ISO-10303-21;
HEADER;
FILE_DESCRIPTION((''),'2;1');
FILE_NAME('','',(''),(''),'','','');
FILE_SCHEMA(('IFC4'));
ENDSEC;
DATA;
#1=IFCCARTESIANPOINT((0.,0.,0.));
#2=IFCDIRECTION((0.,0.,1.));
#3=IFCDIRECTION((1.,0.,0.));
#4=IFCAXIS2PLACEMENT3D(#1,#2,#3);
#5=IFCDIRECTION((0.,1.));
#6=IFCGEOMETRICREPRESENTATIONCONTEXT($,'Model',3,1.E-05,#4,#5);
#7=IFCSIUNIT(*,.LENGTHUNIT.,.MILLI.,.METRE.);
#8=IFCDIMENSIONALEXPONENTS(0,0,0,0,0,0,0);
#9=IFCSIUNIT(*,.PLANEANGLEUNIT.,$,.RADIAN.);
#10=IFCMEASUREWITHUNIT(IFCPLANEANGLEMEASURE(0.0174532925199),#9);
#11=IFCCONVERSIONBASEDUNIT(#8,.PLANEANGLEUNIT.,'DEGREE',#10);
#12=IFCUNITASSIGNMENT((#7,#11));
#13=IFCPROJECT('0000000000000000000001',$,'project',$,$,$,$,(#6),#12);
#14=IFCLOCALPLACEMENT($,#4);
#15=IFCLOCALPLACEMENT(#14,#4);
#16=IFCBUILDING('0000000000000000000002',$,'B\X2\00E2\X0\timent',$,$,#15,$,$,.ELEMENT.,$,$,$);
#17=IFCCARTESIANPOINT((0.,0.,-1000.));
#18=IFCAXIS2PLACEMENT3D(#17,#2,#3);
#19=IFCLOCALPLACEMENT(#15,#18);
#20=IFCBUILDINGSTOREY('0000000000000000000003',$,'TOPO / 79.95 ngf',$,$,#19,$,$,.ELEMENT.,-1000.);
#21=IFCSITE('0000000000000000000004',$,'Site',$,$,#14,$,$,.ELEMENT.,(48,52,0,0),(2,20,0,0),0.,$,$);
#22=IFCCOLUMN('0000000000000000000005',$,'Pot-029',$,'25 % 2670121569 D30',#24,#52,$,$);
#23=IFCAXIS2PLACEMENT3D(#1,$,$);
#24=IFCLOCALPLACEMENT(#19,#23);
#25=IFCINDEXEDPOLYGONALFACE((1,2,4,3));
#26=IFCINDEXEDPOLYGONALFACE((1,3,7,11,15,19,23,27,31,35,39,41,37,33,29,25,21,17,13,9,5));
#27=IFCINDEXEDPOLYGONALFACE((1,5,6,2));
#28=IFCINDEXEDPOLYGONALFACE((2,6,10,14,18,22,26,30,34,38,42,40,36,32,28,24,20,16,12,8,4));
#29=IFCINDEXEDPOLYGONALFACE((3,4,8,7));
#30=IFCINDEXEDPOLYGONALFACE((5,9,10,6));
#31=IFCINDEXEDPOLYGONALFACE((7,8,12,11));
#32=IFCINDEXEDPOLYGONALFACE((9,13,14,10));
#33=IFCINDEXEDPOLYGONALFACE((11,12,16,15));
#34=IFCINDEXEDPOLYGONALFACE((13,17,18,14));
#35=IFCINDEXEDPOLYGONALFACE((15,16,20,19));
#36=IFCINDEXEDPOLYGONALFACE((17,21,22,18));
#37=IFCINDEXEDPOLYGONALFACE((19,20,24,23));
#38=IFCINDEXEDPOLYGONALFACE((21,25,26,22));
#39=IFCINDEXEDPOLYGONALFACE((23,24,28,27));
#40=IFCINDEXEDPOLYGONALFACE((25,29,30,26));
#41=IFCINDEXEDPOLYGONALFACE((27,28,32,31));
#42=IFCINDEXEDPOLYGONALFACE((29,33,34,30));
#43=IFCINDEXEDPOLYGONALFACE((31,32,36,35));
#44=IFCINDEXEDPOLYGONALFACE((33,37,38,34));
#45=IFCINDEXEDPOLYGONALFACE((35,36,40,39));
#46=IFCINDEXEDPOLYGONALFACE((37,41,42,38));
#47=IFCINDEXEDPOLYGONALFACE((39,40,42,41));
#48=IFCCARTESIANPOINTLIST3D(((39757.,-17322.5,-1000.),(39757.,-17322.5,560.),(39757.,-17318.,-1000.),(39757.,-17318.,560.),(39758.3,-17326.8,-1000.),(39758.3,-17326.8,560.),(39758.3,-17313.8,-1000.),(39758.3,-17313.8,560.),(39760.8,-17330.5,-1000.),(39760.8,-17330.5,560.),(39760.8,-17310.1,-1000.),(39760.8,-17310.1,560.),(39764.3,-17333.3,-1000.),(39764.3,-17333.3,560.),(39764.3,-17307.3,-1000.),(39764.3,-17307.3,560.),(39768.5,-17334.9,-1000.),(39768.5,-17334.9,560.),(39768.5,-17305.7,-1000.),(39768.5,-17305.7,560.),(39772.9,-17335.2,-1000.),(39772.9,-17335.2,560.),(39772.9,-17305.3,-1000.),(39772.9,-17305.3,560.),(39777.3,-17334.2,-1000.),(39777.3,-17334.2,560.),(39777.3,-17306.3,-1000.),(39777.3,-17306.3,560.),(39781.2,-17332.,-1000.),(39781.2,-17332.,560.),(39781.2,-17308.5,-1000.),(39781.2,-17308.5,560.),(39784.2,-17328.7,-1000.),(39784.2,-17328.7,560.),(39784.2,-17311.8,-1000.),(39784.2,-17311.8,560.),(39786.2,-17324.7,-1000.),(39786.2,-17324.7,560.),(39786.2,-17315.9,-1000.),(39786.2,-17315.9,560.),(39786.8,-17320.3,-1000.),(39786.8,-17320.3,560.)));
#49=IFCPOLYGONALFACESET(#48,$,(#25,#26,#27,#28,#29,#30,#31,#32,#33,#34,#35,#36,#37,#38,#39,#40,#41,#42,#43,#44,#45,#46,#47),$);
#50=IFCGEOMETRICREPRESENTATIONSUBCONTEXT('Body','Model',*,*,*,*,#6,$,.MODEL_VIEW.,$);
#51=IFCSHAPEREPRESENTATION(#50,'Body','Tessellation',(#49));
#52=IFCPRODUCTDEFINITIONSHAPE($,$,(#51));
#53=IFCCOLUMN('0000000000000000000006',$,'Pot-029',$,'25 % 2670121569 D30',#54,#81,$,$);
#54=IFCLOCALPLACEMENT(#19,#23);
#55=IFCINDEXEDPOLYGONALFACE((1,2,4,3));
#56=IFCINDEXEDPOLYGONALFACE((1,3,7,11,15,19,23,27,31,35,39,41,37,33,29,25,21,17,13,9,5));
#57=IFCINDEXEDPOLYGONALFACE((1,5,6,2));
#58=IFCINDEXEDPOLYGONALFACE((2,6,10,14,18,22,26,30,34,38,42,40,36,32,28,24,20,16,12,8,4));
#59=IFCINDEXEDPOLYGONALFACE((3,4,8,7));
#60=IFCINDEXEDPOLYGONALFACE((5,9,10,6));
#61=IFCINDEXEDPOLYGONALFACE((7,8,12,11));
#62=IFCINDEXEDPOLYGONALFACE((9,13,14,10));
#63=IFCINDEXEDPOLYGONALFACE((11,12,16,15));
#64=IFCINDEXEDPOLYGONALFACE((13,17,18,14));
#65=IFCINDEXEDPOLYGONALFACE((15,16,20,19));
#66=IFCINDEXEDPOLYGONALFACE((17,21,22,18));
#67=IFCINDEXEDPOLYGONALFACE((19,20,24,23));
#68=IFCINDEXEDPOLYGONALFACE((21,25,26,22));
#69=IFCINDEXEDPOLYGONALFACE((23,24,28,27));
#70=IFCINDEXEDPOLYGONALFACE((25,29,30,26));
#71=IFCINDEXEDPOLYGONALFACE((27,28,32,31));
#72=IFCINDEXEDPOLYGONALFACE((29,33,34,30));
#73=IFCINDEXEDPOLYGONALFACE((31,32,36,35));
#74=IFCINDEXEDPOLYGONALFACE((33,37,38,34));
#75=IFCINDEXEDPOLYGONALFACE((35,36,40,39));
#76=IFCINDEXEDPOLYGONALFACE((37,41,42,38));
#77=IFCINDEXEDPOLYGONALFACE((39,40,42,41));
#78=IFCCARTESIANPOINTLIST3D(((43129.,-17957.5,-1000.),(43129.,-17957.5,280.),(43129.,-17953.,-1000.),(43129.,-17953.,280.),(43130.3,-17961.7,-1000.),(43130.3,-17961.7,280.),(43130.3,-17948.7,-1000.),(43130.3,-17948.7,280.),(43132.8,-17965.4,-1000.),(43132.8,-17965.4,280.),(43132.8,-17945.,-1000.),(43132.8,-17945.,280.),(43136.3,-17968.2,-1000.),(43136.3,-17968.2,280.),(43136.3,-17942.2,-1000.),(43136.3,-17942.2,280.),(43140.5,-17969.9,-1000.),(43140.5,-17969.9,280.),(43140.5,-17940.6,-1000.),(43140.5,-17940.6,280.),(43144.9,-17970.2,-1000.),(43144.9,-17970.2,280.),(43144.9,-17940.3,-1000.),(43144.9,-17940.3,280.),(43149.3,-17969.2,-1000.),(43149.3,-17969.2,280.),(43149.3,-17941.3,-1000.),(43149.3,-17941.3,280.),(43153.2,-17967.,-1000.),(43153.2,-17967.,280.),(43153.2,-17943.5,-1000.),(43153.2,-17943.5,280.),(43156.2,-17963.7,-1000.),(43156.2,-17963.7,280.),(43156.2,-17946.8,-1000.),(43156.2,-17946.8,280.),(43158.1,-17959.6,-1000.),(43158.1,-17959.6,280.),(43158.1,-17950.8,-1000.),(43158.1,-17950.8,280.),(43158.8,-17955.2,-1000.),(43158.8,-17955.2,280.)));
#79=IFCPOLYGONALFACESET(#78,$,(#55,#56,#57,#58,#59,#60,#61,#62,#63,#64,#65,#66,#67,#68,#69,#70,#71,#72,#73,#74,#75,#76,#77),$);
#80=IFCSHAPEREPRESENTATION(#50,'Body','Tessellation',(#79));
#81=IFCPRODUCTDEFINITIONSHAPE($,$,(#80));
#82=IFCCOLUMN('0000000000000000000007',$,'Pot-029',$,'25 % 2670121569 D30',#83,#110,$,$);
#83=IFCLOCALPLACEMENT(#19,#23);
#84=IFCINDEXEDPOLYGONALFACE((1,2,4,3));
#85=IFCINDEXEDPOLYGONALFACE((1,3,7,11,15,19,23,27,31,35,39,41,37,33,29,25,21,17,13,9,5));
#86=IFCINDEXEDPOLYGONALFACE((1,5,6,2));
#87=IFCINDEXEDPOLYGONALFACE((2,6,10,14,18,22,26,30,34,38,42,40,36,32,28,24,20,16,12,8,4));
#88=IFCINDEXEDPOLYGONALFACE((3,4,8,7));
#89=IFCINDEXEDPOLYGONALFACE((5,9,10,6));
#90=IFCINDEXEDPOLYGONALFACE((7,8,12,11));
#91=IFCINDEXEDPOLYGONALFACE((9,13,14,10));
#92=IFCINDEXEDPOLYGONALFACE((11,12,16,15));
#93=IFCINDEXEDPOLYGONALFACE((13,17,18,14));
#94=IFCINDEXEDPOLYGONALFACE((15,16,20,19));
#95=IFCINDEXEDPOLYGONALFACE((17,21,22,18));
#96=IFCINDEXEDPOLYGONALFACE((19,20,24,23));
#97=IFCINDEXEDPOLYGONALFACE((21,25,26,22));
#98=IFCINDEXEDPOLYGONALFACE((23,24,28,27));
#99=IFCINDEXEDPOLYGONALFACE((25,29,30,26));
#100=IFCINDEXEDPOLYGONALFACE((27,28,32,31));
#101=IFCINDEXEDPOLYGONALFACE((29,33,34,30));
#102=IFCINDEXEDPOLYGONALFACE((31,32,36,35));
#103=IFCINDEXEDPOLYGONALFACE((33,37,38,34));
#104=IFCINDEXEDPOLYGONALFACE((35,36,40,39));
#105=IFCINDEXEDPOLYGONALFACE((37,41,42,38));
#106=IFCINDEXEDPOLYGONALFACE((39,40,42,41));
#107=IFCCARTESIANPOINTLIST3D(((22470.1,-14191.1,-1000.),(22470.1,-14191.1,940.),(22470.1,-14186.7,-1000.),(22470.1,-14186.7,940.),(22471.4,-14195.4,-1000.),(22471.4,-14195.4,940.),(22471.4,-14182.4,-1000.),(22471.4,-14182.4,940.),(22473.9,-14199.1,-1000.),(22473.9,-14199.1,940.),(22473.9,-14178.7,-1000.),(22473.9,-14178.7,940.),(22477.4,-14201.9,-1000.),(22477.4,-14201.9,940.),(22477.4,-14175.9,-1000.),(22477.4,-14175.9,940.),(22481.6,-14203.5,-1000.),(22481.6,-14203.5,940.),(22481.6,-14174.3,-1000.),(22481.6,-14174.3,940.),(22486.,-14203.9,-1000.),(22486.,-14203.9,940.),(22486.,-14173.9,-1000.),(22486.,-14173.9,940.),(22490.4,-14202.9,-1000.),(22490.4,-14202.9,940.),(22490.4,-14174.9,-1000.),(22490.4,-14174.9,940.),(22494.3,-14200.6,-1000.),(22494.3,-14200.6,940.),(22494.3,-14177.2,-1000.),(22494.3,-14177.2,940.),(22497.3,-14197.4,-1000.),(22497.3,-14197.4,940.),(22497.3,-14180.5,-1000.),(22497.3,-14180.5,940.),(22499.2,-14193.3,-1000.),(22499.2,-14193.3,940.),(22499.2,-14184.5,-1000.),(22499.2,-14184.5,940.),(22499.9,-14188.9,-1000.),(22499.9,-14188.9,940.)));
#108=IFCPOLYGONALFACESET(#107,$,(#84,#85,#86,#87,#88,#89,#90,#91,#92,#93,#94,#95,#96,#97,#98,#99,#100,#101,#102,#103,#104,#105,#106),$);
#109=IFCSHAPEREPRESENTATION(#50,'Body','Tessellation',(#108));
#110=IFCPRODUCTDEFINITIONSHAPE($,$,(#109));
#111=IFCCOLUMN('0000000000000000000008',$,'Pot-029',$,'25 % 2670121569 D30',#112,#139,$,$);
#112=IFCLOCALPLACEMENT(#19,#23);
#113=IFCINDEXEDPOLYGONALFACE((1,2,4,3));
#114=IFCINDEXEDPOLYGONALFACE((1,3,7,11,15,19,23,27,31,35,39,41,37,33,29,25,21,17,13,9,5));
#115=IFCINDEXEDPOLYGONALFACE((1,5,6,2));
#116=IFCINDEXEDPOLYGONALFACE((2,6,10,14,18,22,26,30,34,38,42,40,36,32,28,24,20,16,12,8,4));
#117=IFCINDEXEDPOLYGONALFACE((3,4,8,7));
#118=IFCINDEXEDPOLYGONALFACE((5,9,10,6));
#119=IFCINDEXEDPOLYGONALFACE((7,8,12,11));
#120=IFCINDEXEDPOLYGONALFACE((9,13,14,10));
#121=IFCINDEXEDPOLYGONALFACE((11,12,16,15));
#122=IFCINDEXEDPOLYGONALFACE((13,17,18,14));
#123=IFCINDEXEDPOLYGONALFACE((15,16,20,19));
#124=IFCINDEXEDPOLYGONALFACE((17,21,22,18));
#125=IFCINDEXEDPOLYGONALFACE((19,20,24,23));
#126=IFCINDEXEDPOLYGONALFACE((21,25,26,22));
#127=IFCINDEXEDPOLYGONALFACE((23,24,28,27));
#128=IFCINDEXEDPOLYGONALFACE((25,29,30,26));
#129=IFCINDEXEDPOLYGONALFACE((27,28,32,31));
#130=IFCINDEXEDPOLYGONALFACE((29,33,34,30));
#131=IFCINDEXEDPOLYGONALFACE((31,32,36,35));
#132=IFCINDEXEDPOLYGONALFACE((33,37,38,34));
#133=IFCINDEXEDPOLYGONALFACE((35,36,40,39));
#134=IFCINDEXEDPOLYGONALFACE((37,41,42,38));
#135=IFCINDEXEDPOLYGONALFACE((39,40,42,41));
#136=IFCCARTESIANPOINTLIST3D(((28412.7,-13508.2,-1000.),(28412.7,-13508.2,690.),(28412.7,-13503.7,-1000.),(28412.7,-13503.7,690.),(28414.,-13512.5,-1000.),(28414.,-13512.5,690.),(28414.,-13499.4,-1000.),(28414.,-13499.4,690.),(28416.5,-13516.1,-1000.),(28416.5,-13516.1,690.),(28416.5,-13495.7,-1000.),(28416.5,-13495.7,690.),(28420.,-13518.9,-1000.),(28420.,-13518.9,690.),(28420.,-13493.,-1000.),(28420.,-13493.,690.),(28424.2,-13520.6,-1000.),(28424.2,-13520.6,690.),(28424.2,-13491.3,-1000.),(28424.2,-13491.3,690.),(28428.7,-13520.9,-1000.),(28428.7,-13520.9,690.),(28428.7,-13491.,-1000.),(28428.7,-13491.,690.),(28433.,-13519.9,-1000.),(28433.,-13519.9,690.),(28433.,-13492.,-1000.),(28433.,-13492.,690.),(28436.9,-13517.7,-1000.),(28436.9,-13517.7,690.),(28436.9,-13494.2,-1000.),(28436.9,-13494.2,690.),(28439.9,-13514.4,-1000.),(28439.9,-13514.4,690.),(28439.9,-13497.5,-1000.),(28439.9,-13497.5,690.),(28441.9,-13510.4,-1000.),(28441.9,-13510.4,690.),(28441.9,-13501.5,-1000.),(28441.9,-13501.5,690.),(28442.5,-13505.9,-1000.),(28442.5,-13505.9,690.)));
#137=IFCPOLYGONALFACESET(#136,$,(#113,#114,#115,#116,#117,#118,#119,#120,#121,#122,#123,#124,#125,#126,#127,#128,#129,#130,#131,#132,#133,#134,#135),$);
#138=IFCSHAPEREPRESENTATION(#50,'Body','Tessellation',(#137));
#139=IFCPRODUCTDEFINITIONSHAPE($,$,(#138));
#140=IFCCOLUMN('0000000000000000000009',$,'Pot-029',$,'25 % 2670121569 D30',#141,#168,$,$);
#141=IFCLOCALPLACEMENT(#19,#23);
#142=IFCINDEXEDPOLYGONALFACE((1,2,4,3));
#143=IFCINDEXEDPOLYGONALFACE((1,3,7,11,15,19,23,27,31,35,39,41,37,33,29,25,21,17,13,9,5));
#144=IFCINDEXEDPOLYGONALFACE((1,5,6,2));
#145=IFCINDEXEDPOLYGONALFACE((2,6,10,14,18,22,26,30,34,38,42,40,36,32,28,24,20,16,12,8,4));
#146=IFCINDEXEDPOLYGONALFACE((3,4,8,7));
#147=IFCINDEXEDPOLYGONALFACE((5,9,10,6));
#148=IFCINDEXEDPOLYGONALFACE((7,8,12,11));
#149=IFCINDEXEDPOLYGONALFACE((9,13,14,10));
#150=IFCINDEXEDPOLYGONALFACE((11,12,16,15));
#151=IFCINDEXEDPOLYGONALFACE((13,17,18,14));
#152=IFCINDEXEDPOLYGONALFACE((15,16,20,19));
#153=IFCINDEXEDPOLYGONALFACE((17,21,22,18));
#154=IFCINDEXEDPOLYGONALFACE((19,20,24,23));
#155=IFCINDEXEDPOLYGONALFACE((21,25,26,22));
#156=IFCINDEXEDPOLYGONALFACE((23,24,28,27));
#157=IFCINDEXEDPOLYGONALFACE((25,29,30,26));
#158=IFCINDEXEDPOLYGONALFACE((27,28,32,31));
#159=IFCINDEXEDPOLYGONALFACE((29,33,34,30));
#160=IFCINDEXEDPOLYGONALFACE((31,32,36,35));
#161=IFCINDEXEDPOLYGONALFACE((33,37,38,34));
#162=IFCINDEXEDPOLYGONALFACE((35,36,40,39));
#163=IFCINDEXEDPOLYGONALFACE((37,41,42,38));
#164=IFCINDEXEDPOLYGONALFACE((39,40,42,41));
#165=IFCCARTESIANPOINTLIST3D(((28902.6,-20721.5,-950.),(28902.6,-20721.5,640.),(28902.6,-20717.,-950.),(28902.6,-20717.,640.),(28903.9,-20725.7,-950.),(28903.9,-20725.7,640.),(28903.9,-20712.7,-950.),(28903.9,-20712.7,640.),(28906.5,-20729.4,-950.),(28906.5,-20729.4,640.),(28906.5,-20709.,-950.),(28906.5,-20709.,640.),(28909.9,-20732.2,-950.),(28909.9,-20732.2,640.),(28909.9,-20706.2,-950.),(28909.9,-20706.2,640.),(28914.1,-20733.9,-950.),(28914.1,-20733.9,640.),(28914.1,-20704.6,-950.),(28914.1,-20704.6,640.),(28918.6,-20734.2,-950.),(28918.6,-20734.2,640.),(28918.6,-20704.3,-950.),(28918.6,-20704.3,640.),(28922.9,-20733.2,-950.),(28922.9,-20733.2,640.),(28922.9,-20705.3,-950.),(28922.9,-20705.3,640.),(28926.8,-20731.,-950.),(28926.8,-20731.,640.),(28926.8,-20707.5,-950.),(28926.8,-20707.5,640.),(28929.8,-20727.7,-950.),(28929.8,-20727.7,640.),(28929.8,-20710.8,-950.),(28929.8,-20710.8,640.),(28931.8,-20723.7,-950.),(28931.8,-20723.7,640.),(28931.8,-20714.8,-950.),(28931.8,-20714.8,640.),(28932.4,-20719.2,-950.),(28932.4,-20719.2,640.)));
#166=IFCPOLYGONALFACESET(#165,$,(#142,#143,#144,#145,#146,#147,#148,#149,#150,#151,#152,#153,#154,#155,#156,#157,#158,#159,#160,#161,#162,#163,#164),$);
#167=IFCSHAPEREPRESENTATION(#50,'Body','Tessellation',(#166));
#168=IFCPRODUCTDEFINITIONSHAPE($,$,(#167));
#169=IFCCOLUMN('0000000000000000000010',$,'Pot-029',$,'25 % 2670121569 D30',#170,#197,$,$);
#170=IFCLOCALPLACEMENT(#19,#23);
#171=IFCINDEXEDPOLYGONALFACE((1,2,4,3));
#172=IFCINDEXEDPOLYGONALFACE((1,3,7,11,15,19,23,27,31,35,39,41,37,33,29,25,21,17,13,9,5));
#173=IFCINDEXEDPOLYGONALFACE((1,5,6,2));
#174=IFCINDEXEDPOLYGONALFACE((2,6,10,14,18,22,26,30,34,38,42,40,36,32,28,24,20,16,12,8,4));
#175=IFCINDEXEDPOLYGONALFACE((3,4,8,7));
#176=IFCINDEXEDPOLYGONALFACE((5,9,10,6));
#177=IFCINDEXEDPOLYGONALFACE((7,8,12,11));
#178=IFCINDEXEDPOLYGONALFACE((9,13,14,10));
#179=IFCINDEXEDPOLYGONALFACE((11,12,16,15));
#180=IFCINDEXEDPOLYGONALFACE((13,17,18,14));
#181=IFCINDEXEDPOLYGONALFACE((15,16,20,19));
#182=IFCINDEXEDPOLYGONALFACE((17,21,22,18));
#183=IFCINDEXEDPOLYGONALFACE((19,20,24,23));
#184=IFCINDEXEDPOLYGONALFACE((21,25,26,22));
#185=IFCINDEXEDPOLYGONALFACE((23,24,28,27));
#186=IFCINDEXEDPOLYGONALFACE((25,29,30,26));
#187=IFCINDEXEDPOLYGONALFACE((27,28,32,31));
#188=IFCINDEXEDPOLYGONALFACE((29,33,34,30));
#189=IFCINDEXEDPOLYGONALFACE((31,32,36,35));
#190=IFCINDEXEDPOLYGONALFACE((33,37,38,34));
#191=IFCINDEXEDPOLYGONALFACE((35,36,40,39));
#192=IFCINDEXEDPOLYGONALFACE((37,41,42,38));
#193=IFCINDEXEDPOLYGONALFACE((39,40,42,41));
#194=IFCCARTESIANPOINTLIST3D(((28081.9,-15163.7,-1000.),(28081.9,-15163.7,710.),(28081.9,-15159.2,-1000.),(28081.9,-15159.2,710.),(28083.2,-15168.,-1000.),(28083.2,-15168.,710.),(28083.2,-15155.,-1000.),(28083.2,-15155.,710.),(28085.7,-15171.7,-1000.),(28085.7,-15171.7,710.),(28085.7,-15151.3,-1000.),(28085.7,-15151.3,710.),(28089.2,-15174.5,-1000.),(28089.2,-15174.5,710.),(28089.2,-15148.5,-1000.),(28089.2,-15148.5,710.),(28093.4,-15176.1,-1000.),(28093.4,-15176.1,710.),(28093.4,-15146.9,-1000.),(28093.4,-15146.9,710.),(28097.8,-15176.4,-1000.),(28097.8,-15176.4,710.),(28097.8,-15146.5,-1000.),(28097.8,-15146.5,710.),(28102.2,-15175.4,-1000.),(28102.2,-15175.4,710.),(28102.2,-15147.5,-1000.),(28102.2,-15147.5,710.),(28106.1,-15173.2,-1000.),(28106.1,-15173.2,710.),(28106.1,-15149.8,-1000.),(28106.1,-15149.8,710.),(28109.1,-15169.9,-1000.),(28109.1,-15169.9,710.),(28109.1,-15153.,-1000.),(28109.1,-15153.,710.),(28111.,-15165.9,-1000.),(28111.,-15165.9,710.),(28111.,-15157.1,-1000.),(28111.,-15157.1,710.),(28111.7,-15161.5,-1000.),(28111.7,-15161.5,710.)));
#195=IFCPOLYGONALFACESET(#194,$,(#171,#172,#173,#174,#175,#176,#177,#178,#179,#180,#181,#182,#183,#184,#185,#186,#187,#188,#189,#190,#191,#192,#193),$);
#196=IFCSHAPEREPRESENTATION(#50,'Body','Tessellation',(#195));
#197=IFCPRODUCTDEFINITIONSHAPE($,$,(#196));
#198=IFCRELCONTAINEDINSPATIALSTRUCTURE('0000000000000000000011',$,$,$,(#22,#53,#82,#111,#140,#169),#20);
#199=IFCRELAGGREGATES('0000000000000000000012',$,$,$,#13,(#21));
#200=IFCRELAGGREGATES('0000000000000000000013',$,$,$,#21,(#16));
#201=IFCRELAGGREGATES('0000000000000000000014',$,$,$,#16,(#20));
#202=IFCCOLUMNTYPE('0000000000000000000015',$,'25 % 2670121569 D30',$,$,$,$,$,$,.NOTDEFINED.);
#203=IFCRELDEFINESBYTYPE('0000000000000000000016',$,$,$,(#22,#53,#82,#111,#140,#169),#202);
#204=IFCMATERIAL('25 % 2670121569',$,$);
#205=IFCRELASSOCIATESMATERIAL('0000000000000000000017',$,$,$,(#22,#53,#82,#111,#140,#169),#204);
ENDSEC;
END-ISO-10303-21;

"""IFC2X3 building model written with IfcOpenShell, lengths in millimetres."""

from ifc_helpers import new_model, entity, si_unit, converted_unit, direction, frame, origin_with_axes, origin_2d_with_axis, place, context, subcontext, project, spatial, circle, extrude, material, type_object, element, save


model = new_model("IFC2X3")

# Units and contexts
model_context = context("Model", 3, precision=1e-05, world=origin_with_axes(), true_north=direction((0.0, 1.0)))
body_context = subcontext(model_context, "Body", "Model", "MODEL_VIEW")
ifc_project = project(units=[si_unit("LENGTHUNIT", "METRE", prefix="MILLI"), converted_unit("PLANEANGLEUNIT", "DEGREE", entity("IfcPlaneAngleMeasure", 0.0174532925199), si_unit("PLANEANGLEUNIT", "RADIAN"), dimensions=[0, 0, 0, 0, 0, 0, 0])], contexts=[model_context])

# Site, building, storey
site_placement = place(None, origin_with_axes())
site = spatial("IfcSite", under=ifc_project, at=site_placement, Name="Site", CompositionType="ELEMENT", RefLatitude=(48, 52, 0, 0), RefLongitude=(2, 20, 0, 0), RefElevation=0.0)
building_placement = place(site_placement, origin_with_axes())
building = spatial("IfcBuilding", under=site, at=building_placement, Name="Bâtiment", CompositionType="ELEMENT")
storey_placement = place(building_placement, frame((0.0, 0.0, -1000.0), z_axis=(0.0, 0.0, 1.0), x_axis=(1.0, 0.0, 0.0)))
storey = spatial("IfcBuildingStorey", under=building, at=storey_placement, Name="TOPO / 79.95 ngf", CompositionType="ELEMENT", Elevation=-1000.0)

# Columns
ifc_material_1 = material(Name="25 % 2670121569")
column_type_1 = type_object("IfcColumnType", Name="25 % 2670121569 D30", PredefinedType="NOTDEFINED")
column_1_placement = place(storey_placement, frame((39771.8, -17320.3, -1000.0), z_axis=(0.0, 0.0, 1.0), x_axis=(1.0, 0.0, 0.0)))
element("IfcColumn", 1, at=column_1_placement, inside=storey, type_object=column_type_1, material=ifc_material_1, Name="Pot-029", ObjectType="25 % 2670121569 D30", context=body_context, shape_type="SweptSolid", body=[
    extrude(circle(Radius=15.0, at=origin_2d_with_axis()), origin_with_axes(), (0.0, 0.0, 1.0), 1560.0),
])
column_2_placement = place(storey_placement, frame((43143.8, -17955.2, -1000.0), z_axis=(0.0, 0.0, 1.0), x_axis=(1.0, 0.0, 0.0)))
element("IfcColumn", 2, at=column_2_placement, inside=storey, type_object=column_type_1, material=ifc_material_1, Name="Pot-029", ObjectType="25 % 2670121569 D30", context=body_context, shape_type="SweptSolid", body=[
    extrude(circle(Radius=15.0, at=origin_2d_with_axis()), origin_with_axes(), (0.0, 0.0, 1.0), 1280.0),
])
column_3_placement = place(storey_placement, frame((22484.9, -14188.9, -1000.0), z_axis=(0.0, 0.0, 1.0), x_axis=(1.0, 0.0, 0.0)))
element("IfcColumn", 3, at=column_3_placement, inside=storey, type_object=column_type_1, material=ifc_material_1, Name="Pot-029", ObjectType="25 % 2670121569 D30", context=body_context, shape_type="SweptSolid", body=[
    extrude(circle(Radius=15.0, at=origin_2d_with_axis()), origin_with_axes(), (0.0, 0.0, 1.0), 1940.0),
])
column_4_placement = place(storey_placement, frame((28427.5, -13505.9, -1000.0), z_axis=(0.0, 0.0, 1.0), x_axis=(1.0, 0.0, 0.0)))
element("IfcColumn", 4, at=column_4_placement, inside=storey, type_object=column_type_1, material=ifc_material_1, Name="Pot-029", ObjectType="25 % 2670121569 D30", context=body_context, shape_type="SweptSolid", body=[
    extrude(circle(Radius=15.0, at=origin_2d_with_axis()), origin_with_axes(), (0.0, 0.0, 1.0), 1690.0),
])
column_5_placement = place(storey_placement, frame((28917.4, -20719.2, -950.0), z_axis=(0.0, 0.0, 1.0), x_axis=(1.0, 0.0, 0.0)))
element("IfcColumn", 5, at=column_5_placement, inside=storey, type_object=column_type_1, material=ifc_material_1, Name="Pot-029", ObjectType="25 % 2670121569 D30", context=body_context, shape_type="SweptSolid", body=[
    extrude(circle(Radius=15.0, at=origin_2d_with_axis()), origin_with_axes(), (0.0, 0.0, 1.0), 1590.0),
])
column_6_placement = place(storey_placement, frame((28096.7, -15161.5, -1000.0), z_axis=(0.0, 0.0, 1.0), x_axis=(1.0, 0.0, 0.0)))
element("IfcColumn", 6, at=column_6_placement, inside=storey, type_object=column_type_1, material=ifc_material_1, Name="Pot-029", ObjectType="25 % 2670121569 D30", context=body_context, shape_type="SweptSolid", body=[
    extrude(circle(Radius=15.0, at=origin_2d_with_axis()), origin_with_axes(), (0.0, 0.0, 1.0), 1710.0),
])

save(model, "model.ifc")
